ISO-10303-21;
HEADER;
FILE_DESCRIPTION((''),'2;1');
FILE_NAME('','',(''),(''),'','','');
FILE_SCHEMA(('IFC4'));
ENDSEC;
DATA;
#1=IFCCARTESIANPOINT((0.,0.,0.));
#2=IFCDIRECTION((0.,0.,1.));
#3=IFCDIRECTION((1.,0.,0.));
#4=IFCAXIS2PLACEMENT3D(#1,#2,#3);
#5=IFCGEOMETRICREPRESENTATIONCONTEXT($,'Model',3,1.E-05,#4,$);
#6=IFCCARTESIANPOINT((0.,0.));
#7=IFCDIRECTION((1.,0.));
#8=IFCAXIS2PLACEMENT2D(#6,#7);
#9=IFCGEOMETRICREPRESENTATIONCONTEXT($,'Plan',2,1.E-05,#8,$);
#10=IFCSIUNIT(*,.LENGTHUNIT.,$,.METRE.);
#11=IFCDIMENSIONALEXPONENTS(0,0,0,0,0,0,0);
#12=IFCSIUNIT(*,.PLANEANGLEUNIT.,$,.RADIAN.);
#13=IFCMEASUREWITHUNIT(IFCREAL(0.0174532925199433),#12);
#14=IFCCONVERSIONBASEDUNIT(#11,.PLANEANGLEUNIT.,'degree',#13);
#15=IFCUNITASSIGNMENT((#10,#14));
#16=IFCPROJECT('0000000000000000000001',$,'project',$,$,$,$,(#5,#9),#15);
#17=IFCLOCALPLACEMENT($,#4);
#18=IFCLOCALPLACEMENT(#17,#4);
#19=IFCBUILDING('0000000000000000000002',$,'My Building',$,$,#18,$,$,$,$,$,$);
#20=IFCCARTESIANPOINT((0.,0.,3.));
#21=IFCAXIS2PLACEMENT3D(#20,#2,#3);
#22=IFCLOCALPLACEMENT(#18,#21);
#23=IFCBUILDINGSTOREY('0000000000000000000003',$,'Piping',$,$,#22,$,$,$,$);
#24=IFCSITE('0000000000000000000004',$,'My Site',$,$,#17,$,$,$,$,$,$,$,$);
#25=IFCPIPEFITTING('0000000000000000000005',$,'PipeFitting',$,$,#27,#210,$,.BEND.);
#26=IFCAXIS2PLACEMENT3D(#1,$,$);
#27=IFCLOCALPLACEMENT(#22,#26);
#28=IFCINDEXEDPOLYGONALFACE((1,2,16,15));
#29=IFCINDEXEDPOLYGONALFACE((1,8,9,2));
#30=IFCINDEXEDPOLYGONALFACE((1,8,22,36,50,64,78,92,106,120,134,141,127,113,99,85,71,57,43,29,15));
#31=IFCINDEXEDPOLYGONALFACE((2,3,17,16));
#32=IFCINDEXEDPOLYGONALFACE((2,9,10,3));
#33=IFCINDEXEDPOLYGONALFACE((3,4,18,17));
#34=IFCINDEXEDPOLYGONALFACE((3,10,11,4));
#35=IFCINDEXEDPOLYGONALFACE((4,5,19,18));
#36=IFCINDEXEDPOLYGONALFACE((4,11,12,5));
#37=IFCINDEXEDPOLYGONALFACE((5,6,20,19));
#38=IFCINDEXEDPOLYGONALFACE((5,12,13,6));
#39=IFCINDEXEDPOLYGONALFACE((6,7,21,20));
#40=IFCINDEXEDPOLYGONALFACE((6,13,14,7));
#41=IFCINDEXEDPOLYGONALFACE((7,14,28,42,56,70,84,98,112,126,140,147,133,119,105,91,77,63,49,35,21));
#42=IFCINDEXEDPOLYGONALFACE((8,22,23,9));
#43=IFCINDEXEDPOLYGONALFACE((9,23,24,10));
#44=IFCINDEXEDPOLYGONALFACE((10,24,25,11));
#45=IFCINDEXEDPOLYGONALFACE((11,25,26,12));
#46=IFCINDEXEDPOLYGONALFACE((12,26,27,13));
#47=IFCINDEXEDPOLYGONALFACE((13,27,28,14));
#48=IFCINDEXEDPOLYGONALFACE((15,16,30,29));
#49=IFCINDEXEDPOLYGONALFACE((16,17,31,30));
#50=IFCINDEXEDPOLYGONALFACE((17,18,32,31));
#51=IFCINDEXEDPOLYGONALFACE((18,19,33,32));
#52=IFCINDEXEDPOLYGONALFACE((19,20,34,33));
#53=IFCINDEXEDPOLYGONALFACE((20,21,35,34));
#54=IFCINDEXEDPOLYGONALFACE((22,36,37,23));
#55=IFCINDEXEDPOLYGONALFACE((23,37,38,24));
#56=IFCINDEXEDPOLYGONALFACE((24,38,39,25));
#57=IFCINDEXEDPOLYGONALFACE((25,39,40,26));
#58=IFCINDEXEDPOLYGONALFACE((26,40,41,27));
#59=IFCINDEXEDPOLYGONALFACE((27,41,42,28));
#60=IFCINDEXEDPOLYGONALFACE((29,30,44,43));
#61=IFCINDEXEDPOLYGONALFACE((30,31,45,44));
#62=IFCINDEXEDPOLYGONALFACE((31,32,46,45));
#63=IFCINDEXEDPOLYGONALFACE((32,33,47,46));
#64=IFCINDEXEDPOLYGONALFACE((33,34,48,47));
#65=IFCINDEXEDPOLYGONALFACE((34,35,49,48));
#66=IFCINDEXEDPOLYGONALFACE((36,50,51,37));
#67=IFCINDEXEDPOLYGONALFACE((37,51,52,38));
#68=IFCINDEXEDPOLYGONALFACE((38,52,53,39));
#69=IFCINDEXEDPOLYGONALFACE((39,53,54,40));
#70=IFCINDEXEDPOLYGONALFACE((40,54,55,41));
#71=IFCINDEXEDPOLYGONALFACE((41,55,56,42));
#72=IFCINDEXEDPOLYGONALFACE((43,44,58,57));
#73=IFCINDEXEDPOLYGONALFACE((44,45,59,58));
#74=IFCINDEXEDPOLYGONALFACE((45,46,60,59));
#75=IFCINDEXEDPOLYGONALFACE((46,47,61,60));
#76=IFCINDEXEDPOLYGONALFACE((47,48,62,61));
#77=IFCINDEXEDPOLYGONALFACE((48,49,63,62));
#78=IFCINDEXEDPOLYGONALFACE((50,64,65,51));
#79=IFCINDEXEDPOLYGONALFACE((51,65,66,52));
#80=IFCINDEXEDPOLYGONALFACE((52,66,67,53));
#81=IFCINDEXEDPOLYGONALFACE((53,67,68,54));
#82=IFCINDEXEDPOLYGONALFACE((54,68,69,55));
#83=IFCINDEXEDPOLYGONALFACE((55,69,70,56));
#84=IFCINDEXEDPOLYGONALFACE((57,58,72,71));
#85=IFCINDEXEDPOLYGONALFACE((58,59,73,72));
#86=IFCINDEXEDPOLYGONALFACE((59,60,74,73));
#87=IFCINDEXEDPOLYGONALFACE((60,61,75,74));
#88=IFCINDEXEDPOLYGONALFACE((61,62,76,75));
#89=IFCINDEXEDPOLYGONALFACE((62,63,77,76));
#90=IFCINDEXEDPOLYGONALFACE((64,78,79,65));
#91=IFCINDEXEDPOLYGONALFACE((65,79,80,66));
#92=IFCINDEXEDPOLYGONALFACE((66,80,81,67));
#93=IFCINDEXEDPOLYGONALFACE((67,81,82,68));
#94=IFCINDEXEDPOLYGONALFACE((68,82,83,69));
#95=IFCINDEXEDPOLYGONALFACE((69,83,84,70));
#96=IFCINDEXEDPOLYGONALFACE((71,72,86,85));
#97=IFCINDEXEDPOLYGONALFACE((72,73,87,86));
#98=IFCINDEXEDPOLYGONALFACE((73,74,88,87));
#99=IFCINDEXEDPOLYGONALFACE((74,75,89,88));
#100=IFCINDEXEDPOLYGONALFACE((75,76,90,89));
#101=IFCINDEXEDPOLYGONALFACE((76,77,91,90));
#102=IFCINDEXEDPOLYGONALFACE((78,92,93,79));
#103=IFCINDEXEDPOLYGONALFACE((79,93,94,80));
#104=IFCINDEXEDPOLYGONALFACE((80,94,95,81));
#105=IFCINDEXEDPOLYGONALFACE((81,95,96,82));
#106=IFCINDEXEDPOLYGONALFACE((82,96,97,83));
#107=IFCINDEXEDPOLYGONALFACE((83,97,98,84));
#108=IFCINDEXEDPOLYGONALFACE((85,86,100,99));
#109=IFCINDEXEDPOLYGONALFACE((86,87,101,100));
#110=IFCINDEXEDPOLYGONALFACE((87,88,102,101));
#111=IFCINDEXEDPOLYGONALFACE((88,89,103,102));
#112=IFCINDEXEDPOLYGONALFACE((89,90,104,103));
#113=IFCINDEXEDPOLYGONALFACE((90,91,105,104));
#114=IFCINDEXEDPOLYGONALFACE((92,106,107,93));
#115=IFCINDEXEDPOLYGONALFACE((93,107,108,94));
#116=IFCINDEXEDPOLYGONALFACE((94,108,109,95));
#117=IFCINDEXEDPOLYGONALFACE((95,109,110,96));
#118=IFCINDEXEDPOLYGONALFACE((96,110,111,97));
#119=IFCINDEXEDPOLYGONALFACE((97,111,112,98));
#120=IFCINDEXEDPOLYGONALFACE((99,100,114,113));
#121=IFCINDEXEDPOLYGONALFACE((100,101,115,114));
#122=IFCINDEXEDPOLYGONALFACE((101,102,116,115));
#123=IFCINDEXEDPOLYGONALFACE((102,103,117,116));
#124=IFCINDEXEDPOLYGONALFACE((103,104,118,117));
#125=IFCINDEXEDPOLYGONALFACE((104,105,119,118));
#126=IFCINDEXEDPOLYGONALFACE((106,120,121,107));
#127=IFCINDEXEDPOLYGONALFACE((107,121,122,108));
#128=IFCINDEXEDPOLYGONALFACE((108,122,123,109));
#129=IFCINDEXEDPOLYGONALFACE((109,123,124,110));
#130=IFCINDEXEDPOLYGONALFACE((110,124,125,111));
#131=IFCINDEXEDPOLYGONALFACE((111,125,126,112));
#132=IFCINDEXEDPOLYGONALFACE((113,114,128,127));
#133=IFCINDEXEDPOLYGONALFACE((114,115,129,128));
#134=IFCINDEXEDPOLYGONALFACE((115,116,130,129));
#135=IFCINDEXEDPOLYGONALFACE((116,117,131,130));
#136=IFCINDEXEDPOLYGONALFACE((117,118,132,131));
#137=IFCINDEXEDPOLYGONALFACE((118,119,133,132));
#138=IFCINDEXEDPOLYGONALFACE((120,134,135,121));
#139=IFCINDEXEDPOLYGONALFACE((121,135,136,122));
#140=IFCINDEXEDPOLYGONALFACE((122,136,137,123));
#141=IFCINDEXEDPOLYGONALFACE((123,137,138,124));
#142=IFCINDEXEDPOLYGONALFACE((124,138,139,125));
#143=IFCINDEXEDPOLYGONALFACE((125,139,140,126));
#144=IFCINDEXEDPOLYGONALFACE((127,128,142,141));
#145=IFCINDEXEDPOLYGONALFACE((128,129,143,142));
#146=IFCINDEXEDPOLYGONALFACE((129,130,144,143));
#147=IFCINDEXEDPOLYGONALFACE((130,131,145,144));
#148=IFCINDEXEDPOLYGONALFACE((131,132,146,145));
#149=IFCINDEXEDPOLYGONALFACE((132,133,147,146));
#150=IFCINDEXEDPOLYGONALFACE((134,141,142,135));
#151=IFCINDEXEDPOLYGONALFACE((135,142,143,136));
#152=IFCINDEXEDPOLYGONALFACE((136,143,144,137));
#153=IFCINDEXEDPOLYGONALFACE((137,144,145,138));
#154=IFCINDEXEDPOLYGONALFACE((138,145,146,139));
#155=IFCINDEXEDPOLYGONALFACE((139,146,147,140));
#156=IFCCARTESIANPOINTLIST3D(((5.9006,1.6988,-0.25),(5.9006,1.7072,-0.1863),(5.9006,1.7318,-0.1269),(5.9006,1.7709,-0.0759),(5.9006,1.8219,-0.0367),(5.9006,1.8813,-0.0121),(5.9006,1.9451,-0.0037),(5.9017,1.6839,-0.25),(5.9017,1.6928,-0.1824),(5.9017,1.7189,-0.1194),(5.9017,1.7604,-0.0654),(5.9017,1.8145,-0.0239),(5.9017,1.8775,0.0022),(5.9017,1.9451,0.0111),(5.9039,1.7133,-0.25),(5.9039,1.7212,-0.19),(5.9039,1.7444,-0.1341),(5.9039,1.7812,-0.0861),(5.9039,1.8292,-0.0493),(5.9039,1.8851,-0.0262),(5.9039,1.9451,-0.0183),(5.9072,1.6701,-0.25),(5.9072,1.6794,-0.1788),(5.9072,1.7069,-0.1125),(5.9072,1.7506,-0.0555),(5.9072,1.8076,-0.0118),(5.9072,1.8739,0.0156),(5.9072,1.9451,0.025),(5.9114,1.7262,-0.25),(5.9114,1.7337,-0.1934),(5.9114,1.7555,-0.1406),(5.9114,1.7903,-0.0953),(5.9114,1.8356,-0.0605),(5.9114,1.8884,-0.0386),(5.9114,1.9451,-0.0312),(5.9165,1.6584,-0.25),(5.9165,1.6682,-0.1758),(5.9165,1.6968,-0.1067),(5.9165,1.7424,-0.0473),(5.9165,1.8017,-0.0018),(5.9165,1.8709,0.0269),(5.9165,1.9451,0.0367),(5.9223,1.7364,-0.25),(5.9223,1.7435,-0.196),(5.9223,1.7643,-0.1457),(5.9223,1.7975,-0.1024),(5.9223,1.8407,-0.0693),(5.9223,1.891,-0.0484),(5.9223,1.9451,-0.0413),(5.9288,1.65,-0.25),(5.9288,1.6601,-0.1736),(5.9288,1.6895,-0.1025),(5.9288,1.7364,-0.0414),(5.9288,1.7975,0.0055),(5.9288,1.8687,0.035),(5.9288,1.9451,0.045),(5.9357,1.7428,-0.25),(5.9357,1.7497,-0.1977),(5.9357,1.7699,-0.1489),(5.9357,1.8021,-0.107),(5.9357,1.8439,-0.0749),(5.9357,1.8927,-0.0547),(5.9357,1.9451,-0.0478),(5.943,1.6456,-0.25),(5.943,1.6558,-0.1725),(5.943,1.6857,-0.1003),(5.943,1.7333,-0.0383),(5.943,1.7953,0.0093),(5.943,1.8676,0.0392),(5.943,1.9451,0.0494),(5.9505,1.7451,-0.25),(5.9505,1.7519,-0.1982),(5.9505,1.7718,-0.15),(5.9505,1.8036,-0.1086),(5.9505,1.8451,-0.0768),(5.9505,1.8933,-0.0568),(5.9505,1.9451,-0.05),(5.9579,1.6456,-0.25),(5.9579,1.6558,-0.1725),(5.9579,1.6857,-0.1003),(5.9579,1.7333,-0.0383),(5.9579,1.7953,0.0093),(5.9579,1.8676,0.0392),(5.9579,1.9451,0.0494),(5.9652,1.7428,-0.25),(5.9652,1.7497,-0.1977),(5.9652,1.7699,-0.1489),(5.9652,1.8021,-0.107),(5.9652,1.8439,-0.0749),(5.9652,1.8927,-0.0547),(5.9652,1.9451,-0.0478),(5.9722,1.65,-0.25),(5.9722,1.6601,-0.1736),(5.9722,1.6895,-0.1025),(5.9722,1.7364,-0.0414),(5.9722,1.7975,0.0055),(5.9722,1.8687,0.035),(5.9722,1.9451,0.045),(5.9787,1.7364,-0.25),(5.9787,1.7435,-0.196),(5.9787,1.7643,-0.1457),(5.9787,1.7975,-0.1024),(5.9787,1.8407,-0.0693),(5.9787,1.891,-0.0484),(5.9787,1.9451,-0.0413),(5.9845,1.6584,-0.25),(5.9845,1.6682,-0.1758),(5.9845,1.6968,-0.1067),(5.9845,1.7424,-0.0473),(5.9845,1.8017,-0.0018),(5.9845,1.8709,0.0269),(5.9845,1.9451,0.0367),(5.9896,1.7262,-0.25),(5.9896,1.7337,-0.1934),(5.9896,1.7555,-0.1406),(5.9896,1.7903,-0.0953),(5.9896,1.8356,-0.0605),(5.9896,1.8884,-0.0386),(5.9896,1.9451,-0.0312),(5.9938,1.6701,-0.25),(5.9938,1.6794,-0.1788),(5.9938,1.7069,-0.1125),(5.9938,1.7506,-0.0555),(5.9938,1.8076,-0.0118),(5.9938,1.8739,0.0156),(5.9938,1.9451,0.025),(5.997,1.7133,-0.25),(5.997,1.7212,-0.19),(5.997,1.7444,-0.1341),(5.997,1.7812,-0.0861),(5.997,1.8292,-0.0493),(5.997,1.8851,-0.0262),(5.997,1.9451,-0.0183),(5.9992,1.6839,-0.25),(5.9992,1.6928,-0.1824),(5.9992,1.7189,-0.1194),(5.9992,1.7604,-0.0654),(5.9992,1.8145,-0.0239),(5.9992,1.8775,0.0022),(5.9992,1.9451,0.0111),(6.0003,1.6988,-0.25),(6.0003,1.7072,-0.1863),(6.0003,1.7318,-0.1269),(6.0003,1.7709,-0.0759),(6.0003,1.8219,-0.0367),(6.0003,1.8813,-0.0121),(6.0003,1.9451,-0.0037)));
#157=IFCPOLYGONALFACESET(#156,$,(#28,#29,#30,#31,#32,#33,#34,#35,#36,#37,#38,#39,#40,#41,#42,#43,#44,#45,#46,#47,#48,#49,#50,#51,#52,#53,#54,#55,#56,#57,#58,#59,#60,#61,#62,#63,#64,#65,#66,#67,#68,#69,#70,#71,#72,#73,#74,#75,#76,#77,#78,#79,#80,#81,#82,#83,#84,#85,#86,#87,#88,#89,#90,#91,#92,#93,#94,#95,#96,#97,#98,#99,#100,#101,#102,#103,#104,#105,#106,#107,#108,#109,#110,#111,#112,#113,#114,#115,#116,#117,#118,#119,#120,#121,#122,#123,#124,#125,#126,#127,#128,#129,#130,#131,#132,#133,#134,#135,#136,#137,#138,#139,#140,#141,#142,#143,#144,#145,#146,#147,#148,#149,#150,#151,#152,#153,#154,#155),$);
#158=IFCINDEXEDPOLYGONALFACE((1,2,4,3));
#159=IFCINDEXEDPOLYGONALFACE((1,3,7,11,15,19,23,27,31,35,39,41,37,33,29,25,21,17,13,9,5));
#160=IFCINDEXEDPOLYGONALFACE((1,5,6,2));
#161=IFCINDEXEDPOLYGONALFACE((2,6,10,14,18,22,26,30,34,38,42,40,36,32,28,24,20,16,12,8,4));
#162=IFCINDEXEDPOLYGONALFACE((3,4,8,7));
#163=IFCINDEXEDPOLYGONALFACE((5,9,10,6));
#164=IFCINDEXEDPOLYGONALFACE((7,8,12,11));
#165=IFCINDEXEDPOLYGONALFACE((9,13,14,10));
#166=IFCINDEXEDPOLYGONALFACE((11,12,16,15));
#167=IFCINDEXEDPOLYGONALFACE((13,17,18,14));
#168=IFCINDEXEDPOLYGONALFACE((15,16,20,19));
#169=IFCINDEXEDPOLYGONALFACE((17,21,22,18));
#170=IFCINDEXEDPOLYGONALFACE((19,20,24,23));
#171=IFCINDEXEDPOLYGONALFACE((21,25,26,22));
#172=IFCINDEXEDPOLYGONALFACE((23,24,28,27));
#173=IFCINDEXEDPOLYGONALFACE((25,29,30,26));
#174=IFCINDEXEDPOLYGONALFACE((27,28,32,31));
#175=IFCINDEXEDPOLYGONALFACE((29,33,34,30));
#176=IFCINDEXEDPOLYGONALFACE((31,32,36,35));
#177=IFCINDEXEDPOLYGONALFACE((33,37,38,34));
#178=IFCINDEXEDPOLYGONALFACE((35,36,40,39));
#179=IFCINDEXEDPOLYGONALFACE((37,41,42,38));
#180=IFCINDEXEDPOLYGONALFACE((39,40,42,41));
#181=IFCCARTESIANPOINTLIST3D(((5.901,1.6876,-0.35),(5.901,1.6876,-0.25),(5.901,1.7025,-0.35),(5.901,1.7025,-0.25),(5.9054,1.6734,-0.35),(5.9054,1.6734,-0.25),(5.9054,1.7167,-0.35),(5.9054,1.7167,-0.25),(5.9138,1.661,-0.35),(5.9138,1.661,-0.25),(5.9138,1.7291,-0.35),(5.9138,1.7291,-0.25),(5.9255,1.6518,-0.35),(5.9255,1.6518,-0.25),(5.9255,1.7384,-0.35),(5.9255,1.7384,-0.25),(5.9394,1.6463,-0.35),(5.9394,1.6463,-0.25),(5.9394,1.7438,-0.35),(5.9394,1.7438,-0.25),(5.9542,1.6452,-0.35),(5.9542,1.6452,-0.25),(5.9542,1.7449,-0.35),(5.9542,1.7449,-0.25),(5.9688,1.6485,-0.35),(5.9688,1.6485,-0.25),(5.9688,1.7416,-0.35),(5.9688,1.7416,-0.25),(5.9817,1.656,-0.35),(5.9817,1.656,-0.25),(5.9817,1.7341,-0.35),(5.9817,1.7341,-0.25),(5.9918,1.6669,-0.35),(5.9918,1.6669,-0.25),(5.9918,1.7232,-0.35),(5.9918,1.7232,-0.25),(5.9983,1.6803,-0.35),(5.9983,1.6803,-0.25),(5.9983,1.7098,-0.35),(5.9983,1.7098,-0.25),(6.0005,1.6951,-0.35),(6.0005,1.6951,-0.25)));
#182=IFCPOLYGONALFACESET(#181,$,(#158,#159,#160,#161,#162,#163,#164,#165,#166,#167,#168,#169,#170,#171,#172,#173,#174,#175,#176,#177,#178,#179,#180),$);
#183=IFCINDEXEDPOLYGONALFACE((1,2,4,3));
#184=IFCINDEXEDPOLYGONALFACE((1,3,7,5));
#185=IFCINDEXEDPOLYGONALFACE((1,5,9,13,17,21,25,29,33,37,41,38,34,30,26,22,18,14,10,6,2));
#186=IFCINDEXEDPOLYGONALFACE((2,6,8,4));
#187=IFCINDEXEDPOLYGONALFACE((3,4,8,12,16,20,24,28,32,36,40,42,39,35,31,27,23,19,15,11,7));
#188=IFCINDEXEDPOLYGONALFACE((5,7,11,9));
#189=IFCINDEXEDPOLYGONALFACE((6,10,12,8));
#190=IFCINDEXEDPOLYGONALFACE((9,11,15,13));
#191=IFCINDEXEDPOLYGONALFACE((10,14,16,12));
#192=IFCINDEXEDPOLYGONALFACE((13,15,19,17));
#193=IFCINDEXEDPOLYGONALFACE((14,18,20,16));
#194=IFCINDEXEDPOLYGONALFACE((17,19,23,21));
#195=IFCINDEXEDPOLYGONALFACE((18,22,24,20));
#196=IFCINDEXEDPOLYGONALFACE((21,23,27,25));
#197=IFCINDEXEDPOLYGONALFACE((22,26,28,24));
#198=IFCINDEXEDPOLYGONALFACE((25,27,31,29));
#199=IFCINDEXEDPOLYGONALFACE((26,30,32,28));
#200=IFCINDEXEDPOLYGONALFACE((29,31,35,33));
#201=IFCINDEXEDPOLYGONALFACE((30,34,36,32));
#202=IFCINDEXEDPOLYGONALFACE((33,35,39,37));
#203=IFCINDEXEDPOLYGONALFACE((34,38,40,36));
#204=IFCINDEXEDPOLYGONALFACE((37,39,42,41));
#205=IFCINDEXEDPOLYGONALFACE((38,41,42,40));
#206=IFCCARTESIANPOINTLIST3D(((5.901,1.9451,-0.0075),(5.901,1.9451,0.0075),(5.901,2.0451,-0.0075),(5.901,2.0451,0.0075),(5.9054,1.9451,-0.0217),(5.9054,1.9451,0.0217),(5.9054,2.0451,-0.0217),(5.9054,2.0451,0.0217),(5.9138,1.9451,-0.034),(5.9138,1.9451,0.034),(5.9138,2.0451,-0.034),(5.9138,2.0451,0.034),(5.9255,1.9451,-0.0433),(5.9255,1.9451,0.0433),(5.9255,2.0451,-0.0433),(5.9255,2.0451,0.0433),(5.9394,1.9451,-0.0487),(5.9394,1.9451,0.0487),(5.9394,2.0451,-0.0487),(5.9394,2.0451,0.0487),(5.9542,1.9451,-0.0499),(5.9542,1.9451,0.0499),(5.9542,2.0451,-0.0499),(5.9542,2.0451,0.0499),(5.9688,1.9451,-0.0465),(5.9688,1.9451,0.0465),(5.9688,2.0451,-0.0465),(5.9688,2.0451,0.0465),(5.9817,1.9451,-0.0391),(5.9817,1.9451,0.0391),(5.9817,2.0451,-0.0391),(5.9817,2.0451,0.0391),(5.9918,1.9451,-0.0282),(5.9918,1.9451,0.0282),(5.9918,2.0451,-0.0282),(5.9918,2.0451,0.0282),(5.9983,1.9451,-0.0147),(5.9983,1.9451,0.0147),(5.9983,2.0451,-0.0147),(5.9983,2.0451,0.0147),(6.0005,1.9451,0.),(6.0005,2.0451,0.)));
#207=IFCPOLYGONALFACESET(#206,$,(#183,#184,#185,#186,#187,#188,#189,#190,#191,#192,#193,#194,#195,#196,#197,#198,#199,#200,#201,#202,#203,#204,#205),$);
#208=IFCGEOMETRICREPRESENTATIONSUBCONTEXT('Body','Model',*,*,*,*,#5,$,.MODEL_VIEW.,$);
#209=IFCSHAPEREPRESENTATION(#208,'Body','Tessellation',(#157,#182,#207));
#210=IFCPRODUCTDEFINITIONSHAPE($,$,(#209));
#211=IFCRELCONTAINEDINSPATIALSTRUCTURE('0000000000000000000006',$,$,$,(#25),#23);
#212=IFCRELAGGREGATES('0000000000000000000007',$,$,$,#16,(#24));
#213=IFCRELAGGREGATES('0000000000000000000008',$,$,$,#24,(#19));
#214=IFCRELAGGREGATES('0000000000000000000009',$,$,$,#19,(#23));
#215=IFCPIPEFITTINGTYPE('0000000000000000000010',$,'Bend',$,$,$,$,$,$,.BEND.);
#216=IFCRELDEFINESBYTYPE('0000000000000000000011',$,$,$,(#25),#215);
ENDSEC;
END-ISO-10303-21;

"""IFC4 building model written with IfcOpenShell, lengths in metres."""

from ifc_helpers import new_model, entity, si_unit, converted_unit, frame, origin_with_axes, origin_2d_with_axis, place, context, subcontext, project, spatial, circle, extrude, source, transform, mapped, type_object, type_shapes, element, save


model = new_model("IFC4")

# Units and contexts
model_context = context("Model", 3, precision=1e-05, world=origin_with_axes())
plan_context = context("Plan", 2, precision=1e-05, world=origin_2d_with_axis())
body_context = subcontext(model_context, "Body", "Model", "MODEL_VIEW")
ifc_project = project(units=[si_unit("LENGTHUNIT", "METRE"), converted_unit("PLANEANGLEUNIT", "degree", entity("IfcReal", 0.0174532925199433), si_unit("PLANEANGLEUNIT", "RADIAN"), dimensions=[0, 0, 0, 0, 0, 0, 0])], contexts=[model_context, plan_context])

# Site, building, storey
site_placement = place(None, origin_with_axes())
site = spatial("IfcSite", under=ifc_project, at=site_placement, Name="My Site")
building_placement = place(site_placement, origin_with_axes())
building = spatial("IfcBuilding", under=site, at=building_placement, Name="My Building")
storey_placement = place(building_placement, frame((0.0, 0.0, 3.0), z_axis=(0.0, 0.0, 1.0), x_axis=(1.0, 0.0, 0.0)))
storey = spatial("IfcBuildingStorey", under=building, at=storey_placement, Name="Piping")

# Pipe fitting
pipe_fitting_type = type_object("IfcPipeFittingType", Name="Bend", PredefinedType="BEND")
shared_shape = source(origin_with_axes(), body_context, "Body", "SolidModel", [
    entity("IfcSweptDiskSolid", entity("IfcIndexedPolyCurve", entity("IfcCartesianPointList3D", [[0.0, 0.0, -0.1], [0.0, -0.0732, -0.2768], [0.0, -0.25, -0.35]]), [entity("IfcArcIndex", [1, 2, 3])]), 0.05),
    extrude(circle(Radius=0.05), origin_with_axes(), (0.0, 0.0, -1.0), 0.1),
    extrude(circle(Radius=0.05), frame((0.0, -0.25, -0.35), z_axis=(0.0, -1.0, 0.0), x_axis=(1.0, 0.0, 0.0)), (0.0, 0.0, 1.0), 0.1),
])
type_shapes(pipe_fitting_type, [shared_shape])
for number, where, z_axis, x_axis, name in (
    (1, (5.9505, 1.6951, -0.35), (0.0, 0.0, -1.0), (1.0, 0.0, 0.0), "PipeFitting"),
):
    element("IfcPipeFitting", number, at=place(storey_placement, frame(where, z_axis=z_axis, x_axis=x_axis)), inside=storey, type_object=pipe_fitting_type, Name=name, PredefinedType="BEND", context=body_context, shape_type="MappedRepresentation", body=[
        mapped(shared_shape, transform((0.0, 0.0, 0.0), x_axis=(1.0, 0.0, 0.0), y_axis=(0.0, 1.0, 0.0), z_axis=(0.0, 0.0, 1.0), scale=1.0)),
    ])

save(model, "model.ifc")
